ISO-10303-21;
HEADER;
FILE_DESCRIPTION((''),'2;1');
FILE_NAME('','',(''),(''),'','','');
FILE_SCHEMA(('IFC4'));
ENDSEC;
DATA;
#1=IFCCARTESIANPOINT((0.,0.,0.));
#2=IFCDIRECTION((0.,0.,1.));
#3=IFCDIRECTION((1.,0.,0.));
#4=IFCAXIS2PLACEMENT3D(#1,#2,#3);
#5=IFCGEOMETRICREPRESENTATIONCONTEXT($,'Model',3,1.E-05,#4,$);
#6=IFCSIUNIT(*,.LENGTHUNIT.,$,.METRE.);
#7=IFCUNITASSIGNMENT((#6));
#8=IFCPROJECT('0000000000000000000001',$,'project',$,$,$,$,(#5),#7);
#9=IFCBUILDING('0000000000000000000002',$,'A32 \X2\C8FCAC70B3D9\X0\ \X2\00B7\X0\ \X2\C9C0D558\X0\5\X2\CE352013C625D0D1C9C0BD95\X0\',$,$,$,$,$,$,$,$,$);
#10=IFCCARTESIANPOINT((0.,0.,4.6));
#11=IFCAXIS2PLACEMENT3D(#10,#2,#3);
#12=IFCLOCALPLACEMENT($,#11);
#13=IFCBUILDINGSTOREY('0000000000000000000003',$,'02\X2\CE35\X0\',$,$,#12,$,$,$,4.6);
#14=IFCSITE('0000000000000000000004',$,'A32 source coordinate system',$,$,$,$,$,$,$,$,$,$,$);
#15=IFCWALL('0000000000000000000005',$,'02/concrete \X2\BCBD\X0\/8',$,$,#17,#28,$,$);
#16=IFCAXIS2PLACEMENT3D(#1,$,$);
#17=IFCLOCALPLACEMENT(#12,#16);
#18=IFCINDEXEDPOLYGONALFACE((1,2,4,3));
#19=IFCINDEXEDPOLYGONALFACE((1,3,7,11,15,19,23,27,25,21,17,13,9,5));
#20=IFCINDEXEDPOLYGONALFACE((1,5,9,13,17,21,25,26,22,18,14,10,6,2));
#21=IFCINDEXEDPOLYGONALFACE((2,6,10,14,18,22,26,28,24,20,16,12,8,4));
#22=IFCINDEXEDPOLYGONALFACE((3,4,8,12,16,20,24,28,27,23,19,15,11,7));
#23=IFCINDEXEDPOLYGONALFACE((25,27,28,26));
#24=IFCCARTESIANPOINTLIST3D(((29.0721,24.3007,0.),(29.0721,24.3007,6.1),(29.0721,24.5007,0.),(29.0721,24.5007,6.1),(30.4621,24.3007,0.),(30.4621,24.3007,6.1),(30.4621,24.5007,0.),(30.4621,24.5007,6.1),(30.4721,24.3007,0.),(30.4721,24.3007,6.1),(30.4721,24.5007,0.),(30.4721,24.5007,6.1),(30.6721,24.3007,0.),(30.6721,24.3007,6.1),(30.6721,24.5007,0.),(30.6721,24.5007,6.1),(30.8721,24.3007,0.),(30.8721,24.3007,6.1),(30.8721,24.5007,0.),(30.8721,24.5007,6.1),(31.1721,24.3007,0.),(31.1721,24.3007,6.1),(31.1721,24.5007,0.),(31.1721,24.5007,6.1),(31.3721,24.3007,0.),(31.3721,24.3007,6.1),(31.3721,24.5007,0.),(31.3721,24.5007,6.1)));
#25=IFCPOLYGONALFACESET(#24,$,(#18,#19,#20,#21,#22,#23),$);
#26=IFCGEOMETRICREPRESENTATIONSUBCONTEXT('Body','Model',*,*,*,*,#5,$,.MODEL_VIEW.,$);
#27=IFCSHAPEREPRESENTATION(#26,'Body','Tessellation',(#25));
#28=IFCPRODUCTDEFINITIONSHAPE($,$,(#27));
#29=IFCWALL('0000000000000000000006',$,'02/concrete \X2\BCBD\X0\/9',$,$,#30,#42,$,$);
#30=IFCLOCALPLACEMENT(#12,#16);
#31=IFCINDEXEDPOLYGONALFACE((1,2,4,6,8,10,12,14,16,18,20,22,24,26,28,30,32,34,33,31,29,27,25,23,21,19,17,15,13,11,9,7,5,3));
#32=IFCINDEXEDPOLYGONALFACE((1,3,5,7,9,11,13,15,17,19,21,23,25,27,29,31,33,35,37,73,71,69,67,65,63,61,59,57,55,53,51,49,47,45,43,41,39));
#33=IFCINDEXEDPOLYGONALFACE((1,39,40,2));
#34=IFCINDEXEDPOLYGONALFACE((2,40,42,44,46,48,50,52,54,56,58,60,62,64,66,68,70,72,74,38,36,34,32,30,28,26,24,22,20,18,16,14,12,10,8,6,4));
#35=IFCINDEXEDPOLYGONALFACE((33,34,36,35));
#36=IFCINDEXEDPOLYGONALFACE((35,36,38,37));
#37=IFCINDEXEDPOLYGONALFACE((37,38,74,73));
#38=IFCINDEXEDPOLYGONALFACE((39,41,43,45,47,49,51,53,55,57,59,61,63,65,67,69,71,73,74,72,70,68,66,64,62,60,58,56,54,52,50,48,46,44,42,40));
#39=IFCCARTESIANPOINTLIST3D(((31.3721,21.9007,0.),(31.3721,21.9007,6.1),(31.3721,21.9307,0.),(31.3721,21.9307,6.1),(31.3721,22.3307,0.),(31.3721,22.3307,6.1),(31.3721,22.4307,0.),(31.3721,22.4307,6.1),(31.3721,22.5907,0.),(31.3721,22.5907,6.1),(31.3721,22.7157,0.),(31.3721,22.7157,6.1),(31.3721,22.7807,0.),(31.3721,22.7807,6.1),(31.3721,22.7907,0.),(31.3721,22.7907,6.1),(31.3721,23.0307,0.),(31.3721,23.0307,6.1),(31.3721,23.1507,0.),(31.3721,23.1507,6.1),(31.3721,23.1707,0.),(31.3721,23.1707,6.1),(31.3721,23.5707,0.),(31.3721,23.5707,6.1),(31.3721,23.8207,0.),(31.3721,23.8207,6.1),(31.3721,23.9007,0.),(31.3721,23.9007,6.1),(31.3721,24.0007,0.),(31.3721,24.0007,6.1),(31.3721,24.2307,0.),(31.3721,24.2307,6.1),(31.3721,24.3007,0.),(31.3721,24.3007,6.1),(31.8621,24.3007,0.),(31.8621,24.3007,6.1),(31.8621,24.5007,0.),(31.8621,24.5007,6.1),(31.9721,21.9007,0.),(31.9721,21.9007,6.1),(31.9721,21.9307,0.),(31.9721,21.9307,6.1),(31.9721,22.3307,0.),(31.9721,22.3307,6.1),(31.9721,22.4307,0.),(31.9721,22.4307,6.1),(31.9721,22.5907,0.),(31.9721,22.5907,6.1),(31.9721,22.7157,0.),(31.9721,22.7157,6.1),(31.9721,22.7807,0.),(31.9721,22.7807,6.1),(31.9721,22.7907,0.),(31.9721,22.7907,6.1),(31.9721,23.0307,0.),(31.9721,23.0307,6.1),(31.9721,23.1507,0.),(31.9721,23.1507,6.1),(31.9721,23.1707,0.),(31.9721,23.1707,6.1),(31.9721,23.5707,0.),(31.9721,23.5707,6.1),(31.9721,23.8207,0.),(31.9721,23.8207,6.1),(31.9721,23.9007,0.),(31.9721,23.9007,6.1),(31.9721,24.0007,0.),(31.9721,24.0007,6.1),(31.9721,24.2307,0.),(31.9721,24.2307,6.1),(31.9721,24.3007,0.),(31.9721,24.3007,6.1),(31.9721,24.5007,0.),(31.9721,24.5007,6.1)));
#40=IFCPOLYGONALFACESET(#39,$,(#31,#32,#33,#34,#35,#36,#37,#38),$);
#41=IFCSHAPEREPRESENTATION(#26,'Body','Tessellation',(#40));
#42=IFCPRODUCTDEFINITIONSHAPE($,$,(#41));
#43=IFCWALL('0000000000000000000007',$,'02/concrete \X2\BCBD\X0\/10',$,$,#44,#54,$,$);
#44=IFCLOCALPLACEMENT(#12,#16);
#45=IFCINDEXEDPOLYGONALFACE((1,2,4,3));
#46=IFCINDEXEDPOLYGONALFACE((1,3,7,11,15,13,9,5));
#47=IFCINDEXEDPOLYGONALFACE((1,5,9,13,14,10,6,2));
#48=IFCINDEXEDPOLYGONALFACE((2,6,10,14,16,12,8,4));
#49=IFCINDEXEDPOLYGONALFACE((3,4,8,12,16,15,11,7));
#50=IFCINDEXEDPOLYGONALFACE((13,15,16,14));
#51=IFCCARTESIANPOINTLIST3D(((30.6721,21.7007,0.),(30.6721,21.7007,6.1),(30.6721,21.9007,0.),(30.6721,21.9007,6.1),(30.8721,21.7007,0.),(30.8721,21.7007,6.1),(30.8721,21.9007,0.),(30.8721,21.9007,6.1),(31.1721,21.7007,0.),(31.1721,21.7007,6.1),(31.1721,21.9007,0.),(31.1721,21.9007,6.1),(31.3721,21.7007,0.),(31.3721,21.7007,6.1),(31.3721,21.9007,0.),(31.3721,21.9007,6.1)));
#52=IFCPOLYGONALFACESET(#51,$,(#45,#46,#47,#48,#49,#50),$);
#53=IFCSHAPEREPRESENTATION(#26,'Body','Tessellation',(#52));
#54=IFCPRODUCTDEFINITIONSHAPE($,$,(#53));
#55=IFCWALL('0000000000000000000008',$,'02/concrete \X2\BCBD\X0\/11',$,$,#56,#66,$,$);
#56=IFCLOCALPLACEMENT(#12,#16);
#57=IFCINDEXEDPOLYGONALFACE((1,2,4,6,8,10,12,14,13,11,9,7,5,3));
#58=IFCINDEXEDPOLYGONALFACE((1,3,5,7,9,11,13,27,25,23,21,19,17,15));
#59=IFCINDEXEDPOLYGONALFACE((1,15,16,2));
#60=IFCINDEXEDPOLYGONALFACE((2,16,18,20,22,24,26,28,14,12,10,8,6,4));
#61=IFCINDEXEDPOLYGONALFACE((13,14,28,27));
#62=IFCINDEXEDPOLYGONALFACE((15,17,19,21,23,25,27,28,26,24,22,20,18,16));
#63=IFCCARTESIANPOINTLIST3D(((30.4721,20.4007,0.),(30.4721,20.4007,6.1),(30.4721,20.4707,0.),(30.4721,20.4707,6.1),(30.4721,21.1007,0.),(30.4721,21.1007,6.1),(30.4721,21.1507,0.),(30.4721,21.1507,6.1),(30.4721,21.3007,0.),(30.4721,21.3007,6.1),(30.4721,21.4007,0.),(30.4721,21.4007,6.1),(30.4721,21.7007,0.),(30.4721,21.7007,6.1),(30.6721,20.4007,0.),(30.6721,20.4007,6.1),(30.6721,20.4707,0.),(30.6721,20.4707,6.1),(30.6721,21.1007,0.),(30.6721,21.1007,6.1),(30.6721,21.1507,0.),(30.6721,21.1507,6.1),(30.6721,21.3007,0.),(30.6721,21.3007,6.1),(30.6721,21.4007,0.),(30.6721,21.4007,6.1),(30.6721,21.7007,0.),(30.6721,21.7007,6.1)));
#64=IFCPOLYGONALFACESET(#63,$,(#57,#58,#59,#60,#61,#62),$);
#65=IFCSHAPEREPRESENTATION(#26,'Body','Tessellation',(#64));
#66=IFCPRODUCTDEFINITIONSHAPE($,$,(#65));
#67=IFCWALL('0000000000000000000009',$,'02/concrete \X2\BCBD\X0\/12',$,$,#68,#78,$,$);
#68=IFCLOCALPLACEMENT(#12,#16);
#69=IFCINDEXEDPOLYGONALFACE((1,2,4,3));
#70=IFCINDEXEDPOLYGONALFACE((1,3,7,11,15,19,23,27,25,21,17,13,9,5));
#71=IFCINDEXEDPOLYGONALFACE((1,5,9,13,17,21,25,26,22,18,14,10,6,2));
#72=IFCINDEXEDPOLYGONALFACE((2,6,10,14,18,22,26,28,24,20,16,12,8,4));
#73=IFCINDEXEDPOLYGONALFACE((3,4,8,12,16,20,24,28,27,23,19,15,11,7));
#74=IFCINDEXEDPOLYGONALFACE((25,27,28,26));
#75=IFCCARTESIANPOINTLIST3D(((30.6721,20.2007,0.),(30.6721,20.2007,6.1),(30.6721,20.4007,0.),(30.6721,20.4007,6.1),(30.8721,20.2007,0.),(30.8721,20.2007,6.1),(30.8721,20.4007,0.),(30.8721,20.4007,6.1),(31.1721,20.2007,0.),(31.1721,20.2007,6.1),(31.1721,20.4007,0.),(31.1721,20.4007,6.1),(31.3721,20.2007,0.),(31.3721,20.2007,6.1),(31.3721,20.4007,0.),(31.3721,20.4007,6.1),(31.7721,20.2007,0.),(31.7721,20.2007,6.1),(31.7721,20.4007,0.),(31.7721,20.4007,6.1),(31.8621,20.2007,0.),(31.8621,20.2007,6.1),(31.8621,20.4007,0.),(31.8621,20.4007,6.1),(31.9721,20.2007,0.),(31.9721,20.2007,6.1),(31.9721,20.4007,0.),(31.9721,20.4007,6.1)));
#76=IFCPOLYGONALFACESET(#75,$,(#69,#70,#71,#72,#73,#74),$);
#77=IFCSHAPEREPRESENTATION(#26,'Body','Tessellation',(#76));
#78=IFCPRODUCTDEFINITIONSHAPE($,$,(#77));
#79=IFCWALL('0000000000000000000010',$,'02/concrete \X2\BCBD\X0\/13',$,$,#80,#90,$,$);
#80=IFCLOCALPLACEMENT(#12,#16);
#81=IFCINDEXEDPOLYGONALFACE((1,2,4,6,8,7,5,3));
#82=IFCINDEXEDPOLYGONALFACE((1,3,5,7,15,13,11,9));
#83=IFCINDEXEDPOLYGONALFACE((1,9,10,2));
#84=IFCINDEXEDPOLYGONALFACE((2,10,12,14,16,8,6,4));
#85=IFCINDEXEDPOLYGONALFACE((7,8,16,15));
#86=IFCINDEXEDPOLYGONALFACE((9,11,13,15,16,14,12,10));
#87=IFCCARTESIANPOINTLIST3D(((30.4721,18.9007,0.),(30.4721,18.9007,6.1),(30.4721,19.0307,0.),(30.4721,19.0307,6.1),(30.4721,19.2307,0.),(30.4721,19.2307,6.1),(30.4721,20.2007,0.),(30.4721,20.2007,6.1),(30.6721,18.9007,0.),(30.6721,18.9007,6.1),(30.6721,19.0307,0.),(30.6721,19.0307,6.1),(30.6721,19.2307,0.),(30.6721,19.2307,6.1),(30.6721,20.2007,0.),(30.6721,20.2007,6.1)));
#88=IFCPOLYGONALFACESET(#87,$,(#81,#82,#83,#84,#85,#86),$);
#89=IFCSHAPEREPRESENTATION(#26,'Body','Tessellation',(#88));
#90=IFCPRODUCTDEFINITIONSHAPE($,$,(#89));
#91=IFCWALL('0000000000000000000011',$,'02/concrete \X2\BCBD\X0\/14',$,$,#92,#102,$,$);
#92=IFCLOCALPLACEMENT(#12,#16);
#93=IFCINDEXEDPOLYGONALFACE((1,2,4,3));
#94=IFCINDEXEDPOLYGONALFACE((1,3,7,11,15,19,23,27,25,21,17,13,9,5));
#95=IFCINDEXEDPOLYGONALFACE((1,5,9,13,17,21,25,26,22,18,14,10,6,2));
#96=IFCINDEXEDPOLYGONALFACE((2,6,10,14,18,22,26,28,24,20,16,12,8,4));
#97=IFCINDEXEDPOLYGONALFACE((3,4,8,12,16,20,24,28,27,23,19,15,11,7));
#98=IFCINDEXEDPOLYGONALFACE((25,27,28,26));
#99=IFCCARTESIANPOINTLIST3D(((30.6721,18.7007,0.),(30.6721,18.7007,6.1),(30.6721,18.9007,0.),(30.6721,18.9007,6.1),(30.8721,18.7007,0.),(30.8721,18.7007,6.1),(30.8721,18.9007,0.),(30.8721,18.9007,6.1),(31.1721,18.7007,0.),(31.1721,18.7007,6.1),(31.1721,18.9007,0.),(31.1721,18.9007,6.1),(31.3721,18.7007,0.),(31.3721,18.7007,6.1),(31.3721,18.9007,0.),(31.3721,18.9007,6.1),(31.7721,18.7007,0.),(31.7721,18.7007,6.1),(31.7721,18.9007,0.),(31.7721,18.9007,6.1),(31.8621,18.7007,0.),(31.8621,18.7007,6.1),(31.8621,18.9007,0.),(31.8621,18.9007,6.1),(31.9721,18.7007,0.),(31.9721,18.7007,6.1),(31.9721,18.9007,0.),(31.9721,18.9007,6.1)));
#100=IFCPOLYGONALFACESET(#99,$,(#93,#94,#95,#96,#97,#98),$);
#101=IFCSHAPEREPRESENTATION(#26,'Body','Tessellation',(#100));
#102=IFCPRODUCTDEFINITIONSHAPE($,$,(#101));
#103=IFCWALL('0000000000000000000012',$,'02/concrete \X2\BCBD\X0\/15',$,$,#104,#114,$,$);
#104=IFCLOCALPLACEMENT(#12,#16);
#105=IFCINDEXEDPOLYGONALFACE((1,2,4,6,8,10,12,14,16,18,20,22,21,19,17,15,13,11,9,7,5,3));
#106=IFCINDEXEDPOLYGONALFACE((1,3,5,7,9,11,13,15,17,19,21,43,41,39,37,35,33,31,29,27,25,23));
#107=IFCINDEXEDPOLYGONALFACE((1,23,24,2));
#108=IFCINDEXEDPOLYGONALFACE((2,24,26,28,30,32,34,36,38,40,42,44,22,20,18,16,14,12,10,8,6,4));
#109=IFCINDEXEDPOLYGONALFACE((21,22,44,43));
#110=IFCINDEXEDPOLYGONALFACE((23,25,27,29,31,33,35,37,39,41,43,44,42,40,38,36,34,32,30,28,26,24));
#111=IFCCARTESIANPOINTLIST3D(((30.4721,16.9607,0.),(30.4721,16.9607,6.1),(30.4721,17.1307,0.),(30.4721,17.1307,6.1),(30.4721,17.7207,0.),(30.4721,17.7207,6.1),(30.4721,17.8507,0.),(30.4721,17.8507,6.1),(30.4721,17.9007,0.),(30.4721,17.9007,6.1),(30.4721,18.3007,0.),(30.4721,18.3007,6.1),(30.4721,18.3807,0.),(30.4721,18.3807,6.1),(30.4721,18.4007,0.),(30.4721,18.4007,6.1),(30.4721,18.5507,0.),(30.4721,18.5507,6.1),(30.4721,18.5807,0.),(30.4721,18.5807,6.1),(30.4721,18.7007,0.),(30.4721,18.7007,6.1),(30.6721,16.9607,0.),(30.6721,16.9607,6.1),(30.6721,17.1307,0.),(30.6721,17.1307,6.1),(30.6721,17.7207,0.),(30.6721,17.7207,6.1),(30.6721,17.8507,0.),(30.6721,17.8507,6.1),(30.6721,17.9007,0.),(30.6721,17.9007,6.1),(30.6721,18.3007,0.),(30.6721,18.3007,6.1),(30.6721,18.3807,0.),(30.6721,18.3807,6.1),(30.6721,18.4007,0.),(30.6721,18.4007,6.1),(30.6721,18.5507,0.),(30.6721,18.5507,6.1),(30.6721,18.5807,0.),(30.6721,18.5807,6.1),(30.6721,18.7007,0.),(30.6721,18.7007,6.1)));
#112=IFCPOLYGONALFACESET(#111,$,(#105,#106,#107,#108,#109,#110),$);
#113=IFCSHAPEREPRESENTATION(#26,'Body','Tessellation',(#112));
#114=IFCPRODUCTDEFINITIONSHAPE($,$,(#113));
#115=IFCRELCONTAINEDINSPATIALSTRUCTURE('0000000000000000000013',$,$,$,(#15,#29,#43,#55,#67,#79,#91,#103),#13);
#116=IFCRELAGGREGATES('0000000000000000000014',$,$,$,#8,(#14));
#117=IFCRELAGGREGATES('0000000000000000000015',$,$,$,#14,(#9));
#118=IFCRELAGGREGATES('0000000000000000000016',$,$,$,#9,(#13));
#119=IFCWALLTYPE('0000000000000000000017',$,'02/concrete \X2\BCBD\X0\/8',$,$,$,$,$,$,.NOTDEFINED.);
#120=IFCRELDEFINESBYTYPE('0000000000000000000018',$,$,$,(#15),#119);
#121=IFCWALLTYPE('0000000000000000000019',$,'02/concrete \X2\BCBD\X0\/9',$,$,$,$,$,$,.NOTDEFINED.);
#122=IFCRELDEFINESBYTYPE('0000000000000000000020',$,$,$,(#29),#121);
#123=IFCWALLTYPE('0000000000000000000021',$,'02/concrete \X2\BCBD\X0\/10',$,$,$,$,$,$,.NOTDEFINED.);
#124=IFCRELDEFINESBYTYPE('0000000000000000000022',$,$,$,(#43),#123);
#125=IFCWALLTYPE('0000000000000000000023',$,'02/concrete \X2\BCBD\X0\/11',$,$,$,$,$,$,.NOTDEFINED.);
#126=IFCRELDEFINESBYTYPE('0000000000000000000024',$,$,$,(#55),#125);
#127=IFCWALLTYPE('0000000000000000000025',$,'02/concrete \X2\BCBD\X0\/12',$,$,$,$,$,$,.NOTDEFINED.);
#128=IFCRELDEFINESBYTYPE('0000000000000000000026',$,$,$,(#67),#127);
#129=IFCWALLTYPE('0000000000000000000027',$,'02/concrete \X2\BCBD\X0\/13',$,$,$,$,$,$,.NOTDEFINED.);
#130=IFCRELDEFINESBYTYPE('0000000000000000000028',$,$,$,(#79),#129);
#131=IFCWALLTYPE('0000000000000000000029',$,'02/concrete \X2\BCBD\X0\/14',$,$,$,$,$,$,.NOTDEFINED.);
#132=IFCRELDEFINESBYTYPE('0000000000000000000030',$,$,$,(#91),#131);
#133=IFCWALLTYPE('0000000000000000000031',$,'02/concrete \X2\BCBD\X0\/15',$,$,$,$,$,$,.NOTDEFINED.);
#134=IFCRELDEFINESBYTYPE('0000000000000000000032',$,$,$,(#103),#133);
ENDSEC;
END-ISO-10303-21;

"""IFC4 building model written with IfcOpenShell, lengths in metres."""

from ifc_helpers import new_model, si_unit, frame, origin, origin_with_axes, place, context, subcontext, project, spatial, polyline, outline, extrude, source, transform, mapped, type_object, type_shapes, element, save


model = new_model("IFC4")

# Units and contexts
model_context = context("Model", 3, precision=1e-05, world=origin_with_axes())
body_context = subcontext(model_context, "Body", "Model", "MODEL_VIEW")
ifc_project = project(units=[si_unit("LENGTHUNIT", "METRE")], contexts=[model_context])

# Site, building, storey
site = spatial("IfcSite", under=ifc_project, Name="A32 source coordinate system")
building = spatial("IfcBuilding", under=site, Name="A32 주거동 · 지하5층–옥탑지붕")
storey_placement = place(None, frame((0.0, 0.0, 4.6), z_axis=(0.0, 0.0, 1.0), x_axis=(1.0, 0.0, 0.0)))
storey = spatial("IfcBuildingStorey", under=building, at=storey_placement, Name="02층", Elevation=4.6)

# Walls
wall_type_1 = type_object("IfcWallType", Name="02/concrete 벽/8", PredefinedType="NOTDEFINED")
shared_shape_1 = source(origin(), body_context, "Body", "SweptSolid", [
    extrude(outline(polyline([(30.4721, 24.5007), (30.6721, 24.5007), (30.8721, 24.5007), (31.1721, 24.5007), (31.3721, 24.5007), (31.3721, 24.3007), (31.1721, 24.3007), (30.8721, 24.3007), (30.6721, 24.3007), (30.4721, 24.3007), (30.4621, 24.3007), (29.0721, 24.3007), (29.0721, 24.5007), (30.4621, 24.5007), (30.4721, 24.5007)])), origin(), (0.0, 0.0, 1.0), 6.1),
])
type_shapes(wall_type_1, [shared_shape_1])
wall_1_placement = place(storey_placement, origin_with_axes())
element("IfcWall", 1, at=wall_1_placement, inside=storey, type_object=wall_type_1, Name="02/concrete 벽/8", context=body_context, shape_type="MappedRepresentation", body=[
    mapped(shared_shape_1, transform((0.0, 0.0, 0.0), scale=1.0)),
])
wall_type_2 = type_object("IfcWallType", Name="02/concrete 벽/9", PredefinedType="NOTDEFINED")
shared_shape_2 = source(origin(), body_context, "Body", "SweptSolid", [
    extrude(outline(polyline([(31.9721, 24.5007), (31.9721, 24.3007), (31.9721, 24.2307), (31.9721, 24.0007), (31.9721, 23.9007), (31.9721, 23.8207), (31.9721, 23.5707), (31.9721, 23.1707), (31.9721, 23.1507), (31.9721, 23.0307), (31.9721, 22.7907), (31.9721, 22.7807), (31.9721, 22.7157), (31.9721, 22.5907), (31.9721, 22.4307), (31.9721, 22.3307), (31.9721, 21.9307), (31.9721, 21.9007), (31.3721, 21.9007), (31.3721, 21.9307), (31.3721, 22.3307), (31.3721, 22.4307), (31.3721, 22.5907), (31.3721, 22.7157), (31.3721, 22.7807), (31.3721, 22.7907), (31.3721, 23.0307), (31.3721, 23.1507), (31.3721, 23.1707), (31.3721, 23.5707), (31.3721, 23.8207), (31.3721, 23.9007), (31.3721, 24.0007), (31.3721, 24.2307), (31.3721, 24.3007), (31.8621, 24.3007), (31.8621, 24.5007), (31.9721, 24.5007)])), origin(), (0.0, 0.0, 1.0), 6.1),
])
type_shapes(wall_type_2, [shared_shape_2])
wall_2_placement = place(storey_placement, origin_with_axes())
element("IfcWall", 2, at=wall_2_placement, inside=storey, type_object=wall_type_2, Name="02/concrete 벽/9", context=body_context, shape_type="MappedRepresentation", body=[
    mapped(shared_shape_2, transform((0.0, 0.0, 0.0), scale=1.0)),
])
wall_type_3 = type_object("IfcWallType", Name="02/concrete 벽/10", PredefinedType="NOTDEFINED")
shared_shape_3 = source(origin(), body_context, "Body", "SweptSolid", [
    extrude(outline(polyline([(30.8721, 21.7007), (30.6721, 21.7007), (30.6721, 21.9007), (30.8721, 21.9007), (31.1721, 21.9007), (31.3721, 21.9007), (31.3721, 21.7007), (31.1721, 21.7007), (30.8721, 21.7007)])), origin(), (0.0, 0.0, 1.0), 6.1),
])
type_shapes(wall_type_3, [shared_shape_3])
wall_3_placement = place(storey_placement, origin_with_axes())
element("IfcWall", 3, at=wall_3_placement, inside=storey, type_object=wall_type_3, Name="02/concrete 벽/10", context=body_context, shape_type="MappedRepresentation", body=[
    mapped(shared_shape_3, transform((0.0, 0.0, 0.0), scale=1.0)),
])
wall_type_4 = type_object("IfcWallType", Name="02/concrete 벽/11", PredefinedType="NOTDEFINED")
shared_shape_4 = source(origin(), body_context, "Body", "SweptSolid", [
    extrude(outline(polyline([(30.6721, 21.1507), (30.6721, 21.1007), (30.6721, 20.4707), (30.6721, 20.4007), (30.4721, 20.4007), (30.4721, 20.4707), (30.4721, 21.1007), (30.4721, 21.1507), (30.4721, 21.3007), (30.4721, 21.4007), (30.4721, 21.7007), (30.6721, 21.7007), (30.6721, 21.4007), (30.6721, 21.3007), (30.6721, 21.1507)])), origin(), (0.0, 0.0, 1.0), 6.1),
])
type_shapes(wall_type_4, [shared_shape_4])
wall_4_placement = place(storey_placement, origin_with_axes())
element("IfcWall", 4, at=wall_4_placement, inside=storey, type_object=wall_type_4, Name="02/concrete 벽/11", context=body_context, shape_type="MappedRepresentation", body=[
    mapped(shared_shape_4, transform((0.0, 0.0, 0.0), scale=1.0)),
])
wall_type_5 = type_object("IfcWallType", Name="02/concrete 벽/12", PredefinedType="NOTDEFINED")
shared_shape_5 = source(origin(), body_context, "Body", "SweptSolid", [
    extrude(outline(polyline([(31.3721, 20.4007), (31.7721, 20.4007), (31.8621, 20.4007), (31.9721, 20.4007), (31.9721, 20.2007), (31.8621, 20.2007), (31.7721, 20.2007), (31.3721, 20.2007), (31.1721, 20.2007), (30.8721, 20.2007), (30.6721, 20.2007), (30.6721, 20.4007), (30.8721, 20.4007), (31.1721, 20.4007), (31.3721, 20.4007)])), origin(), (0.0, 0.0, 1.0), 6.1),
])
type_shapes(wall_type_5, [shared_shape_5])
wall_5_placement = place(storey_placement, origin_with_axes())
element("IfcWall", 5, at=wall_5_placement, inside=storey, type_object=wall_type_5, Name="02/concrete 벽/12", context=body_context, shape_type="MappedRepresentation", body=[
    mapped(shared_shape_5, transform((0.0, 0.0, 0.0), scale=1.0)),
])
wall_type_6 = type_object("IfcWallType", Name="02/concrete 벽/13", PredefinedType="NOTDEFINED")
shared_shape_6 = source(origin(), body_context, "Body", "SweptSolid", [
    extrude(outline(polyline([(30.6721, 18.9007), (30.4721, 18.9007), (30.4721, 19.0307), (30.4721, 19.2307), (30.4721, 20.2007), (30.6721, 20.2007), (30.6721, 19.2307), (30.6721, 19.0307), (30.6721, 18.9007)])), origin(), (0.0, 0.0, 1.0), 6.1),
])
type_shapes(wall_type_6, [shared_shape_6])
wall_6_placement = place(storey_placement, origin_with_axes())
element("IfcWall", 6, at=wall_6_placement, inside=storey, type_object=wall_type_6, Name="02/concrete 벽/13", context=body_context, shape_type="MappedRepresentation", body=[
    mapped(shared_shape_6, transform((0.0, 0.0, 0.0), scale=1.0)),
])
wall_type_7 = type_object("IfcWallType", Name="02/concrete 벽/14", PredefinedType="NOTDEFINED")
shared_shape_7 = source(origin(), body_context, "Body", "SweptSolid", [
    extrude(outline(polyline([(31.3721, 18.9007), (31.7721, 18.9007), (31.8621, 18.9007), (31.9721, 18.9007), (31.9721, 18.7007), (31.8621, 18.7007), (31.7721, 18.7007), (31.3721, 18.7007), (31.1721, 18.7007), (30.8721, 18.7007), (30.6721, 18.7007), (30.6721, 18.9007), (30.8721, 18.9007), (31.1721, 18.9007), (31.3721, 18.9007)])), origin(), (0.0, 0.0, 1.0), 6.1),
])
type_shapes(wall_type_7, [shared_shape_7])
wall_7_placement = place(storey_placement, origin_with_axes())
element("IfcWall", 7, at=wall_7_placement, inside=storey, type_object=wall_type_7, Name="02/concrete 벽/14", context=body_context, shape_type="MappedRepresentation", body=[
    mapped(shared_shape_7, transform((0.0, 0.0, 0.0), scale=1.0)),
])
wall_type_8 = type_object("IfcWallType", Name="02/concrete 벽/15", PredefinedType="NOTDEFINED")
shared_shape_8 = source(origin(), body_context, "Body", "SweptSolid", [
    extrude(outline(polyline([(30.6721, 18.4007), (30.6721, 18.3807), (30.6721, 18.3007), (30.6721, 17.9007), (30.6721, 17.8507), (30.6721, 17.7207), (30.6721, 17.1307), (30.6721, 16.9607), (30.4721, 16.9607), (30.4721, 17.1307), (30.4721, 17.7207), (30.4721, 17.8507), (30.4721, 17.9007), (30.4721, 18.3007), (30.4721, 18.3807), (30.4721, 18.4007), (30.4721, 18.5507), (30.4721, 18.5807), (30.4721, 18.7007), (30.6721, 18.7007), (30.6721, 18.5807), (30.6721, 18.5507), (30.6721, 18.4007)])), origin(), (0.0, 0.0, 1.0), 6.1),
])
type_shapes(wall_type_8, [shared_shape_8])
wall_8_placement = place(storey_placement, origin_with_axes())
element("IfcWall", 8, at=wall_8_placement, inside=storey, type_object=wall_type_8, Name="02/concrete 벽/15", context=body_context, shape_type="MappedRepresentation", body=[
    mapped(shared_shape_8, transform((0.0, 0.0, 0.0), scale=1.0)),
])

save(model, "model.ifc")
